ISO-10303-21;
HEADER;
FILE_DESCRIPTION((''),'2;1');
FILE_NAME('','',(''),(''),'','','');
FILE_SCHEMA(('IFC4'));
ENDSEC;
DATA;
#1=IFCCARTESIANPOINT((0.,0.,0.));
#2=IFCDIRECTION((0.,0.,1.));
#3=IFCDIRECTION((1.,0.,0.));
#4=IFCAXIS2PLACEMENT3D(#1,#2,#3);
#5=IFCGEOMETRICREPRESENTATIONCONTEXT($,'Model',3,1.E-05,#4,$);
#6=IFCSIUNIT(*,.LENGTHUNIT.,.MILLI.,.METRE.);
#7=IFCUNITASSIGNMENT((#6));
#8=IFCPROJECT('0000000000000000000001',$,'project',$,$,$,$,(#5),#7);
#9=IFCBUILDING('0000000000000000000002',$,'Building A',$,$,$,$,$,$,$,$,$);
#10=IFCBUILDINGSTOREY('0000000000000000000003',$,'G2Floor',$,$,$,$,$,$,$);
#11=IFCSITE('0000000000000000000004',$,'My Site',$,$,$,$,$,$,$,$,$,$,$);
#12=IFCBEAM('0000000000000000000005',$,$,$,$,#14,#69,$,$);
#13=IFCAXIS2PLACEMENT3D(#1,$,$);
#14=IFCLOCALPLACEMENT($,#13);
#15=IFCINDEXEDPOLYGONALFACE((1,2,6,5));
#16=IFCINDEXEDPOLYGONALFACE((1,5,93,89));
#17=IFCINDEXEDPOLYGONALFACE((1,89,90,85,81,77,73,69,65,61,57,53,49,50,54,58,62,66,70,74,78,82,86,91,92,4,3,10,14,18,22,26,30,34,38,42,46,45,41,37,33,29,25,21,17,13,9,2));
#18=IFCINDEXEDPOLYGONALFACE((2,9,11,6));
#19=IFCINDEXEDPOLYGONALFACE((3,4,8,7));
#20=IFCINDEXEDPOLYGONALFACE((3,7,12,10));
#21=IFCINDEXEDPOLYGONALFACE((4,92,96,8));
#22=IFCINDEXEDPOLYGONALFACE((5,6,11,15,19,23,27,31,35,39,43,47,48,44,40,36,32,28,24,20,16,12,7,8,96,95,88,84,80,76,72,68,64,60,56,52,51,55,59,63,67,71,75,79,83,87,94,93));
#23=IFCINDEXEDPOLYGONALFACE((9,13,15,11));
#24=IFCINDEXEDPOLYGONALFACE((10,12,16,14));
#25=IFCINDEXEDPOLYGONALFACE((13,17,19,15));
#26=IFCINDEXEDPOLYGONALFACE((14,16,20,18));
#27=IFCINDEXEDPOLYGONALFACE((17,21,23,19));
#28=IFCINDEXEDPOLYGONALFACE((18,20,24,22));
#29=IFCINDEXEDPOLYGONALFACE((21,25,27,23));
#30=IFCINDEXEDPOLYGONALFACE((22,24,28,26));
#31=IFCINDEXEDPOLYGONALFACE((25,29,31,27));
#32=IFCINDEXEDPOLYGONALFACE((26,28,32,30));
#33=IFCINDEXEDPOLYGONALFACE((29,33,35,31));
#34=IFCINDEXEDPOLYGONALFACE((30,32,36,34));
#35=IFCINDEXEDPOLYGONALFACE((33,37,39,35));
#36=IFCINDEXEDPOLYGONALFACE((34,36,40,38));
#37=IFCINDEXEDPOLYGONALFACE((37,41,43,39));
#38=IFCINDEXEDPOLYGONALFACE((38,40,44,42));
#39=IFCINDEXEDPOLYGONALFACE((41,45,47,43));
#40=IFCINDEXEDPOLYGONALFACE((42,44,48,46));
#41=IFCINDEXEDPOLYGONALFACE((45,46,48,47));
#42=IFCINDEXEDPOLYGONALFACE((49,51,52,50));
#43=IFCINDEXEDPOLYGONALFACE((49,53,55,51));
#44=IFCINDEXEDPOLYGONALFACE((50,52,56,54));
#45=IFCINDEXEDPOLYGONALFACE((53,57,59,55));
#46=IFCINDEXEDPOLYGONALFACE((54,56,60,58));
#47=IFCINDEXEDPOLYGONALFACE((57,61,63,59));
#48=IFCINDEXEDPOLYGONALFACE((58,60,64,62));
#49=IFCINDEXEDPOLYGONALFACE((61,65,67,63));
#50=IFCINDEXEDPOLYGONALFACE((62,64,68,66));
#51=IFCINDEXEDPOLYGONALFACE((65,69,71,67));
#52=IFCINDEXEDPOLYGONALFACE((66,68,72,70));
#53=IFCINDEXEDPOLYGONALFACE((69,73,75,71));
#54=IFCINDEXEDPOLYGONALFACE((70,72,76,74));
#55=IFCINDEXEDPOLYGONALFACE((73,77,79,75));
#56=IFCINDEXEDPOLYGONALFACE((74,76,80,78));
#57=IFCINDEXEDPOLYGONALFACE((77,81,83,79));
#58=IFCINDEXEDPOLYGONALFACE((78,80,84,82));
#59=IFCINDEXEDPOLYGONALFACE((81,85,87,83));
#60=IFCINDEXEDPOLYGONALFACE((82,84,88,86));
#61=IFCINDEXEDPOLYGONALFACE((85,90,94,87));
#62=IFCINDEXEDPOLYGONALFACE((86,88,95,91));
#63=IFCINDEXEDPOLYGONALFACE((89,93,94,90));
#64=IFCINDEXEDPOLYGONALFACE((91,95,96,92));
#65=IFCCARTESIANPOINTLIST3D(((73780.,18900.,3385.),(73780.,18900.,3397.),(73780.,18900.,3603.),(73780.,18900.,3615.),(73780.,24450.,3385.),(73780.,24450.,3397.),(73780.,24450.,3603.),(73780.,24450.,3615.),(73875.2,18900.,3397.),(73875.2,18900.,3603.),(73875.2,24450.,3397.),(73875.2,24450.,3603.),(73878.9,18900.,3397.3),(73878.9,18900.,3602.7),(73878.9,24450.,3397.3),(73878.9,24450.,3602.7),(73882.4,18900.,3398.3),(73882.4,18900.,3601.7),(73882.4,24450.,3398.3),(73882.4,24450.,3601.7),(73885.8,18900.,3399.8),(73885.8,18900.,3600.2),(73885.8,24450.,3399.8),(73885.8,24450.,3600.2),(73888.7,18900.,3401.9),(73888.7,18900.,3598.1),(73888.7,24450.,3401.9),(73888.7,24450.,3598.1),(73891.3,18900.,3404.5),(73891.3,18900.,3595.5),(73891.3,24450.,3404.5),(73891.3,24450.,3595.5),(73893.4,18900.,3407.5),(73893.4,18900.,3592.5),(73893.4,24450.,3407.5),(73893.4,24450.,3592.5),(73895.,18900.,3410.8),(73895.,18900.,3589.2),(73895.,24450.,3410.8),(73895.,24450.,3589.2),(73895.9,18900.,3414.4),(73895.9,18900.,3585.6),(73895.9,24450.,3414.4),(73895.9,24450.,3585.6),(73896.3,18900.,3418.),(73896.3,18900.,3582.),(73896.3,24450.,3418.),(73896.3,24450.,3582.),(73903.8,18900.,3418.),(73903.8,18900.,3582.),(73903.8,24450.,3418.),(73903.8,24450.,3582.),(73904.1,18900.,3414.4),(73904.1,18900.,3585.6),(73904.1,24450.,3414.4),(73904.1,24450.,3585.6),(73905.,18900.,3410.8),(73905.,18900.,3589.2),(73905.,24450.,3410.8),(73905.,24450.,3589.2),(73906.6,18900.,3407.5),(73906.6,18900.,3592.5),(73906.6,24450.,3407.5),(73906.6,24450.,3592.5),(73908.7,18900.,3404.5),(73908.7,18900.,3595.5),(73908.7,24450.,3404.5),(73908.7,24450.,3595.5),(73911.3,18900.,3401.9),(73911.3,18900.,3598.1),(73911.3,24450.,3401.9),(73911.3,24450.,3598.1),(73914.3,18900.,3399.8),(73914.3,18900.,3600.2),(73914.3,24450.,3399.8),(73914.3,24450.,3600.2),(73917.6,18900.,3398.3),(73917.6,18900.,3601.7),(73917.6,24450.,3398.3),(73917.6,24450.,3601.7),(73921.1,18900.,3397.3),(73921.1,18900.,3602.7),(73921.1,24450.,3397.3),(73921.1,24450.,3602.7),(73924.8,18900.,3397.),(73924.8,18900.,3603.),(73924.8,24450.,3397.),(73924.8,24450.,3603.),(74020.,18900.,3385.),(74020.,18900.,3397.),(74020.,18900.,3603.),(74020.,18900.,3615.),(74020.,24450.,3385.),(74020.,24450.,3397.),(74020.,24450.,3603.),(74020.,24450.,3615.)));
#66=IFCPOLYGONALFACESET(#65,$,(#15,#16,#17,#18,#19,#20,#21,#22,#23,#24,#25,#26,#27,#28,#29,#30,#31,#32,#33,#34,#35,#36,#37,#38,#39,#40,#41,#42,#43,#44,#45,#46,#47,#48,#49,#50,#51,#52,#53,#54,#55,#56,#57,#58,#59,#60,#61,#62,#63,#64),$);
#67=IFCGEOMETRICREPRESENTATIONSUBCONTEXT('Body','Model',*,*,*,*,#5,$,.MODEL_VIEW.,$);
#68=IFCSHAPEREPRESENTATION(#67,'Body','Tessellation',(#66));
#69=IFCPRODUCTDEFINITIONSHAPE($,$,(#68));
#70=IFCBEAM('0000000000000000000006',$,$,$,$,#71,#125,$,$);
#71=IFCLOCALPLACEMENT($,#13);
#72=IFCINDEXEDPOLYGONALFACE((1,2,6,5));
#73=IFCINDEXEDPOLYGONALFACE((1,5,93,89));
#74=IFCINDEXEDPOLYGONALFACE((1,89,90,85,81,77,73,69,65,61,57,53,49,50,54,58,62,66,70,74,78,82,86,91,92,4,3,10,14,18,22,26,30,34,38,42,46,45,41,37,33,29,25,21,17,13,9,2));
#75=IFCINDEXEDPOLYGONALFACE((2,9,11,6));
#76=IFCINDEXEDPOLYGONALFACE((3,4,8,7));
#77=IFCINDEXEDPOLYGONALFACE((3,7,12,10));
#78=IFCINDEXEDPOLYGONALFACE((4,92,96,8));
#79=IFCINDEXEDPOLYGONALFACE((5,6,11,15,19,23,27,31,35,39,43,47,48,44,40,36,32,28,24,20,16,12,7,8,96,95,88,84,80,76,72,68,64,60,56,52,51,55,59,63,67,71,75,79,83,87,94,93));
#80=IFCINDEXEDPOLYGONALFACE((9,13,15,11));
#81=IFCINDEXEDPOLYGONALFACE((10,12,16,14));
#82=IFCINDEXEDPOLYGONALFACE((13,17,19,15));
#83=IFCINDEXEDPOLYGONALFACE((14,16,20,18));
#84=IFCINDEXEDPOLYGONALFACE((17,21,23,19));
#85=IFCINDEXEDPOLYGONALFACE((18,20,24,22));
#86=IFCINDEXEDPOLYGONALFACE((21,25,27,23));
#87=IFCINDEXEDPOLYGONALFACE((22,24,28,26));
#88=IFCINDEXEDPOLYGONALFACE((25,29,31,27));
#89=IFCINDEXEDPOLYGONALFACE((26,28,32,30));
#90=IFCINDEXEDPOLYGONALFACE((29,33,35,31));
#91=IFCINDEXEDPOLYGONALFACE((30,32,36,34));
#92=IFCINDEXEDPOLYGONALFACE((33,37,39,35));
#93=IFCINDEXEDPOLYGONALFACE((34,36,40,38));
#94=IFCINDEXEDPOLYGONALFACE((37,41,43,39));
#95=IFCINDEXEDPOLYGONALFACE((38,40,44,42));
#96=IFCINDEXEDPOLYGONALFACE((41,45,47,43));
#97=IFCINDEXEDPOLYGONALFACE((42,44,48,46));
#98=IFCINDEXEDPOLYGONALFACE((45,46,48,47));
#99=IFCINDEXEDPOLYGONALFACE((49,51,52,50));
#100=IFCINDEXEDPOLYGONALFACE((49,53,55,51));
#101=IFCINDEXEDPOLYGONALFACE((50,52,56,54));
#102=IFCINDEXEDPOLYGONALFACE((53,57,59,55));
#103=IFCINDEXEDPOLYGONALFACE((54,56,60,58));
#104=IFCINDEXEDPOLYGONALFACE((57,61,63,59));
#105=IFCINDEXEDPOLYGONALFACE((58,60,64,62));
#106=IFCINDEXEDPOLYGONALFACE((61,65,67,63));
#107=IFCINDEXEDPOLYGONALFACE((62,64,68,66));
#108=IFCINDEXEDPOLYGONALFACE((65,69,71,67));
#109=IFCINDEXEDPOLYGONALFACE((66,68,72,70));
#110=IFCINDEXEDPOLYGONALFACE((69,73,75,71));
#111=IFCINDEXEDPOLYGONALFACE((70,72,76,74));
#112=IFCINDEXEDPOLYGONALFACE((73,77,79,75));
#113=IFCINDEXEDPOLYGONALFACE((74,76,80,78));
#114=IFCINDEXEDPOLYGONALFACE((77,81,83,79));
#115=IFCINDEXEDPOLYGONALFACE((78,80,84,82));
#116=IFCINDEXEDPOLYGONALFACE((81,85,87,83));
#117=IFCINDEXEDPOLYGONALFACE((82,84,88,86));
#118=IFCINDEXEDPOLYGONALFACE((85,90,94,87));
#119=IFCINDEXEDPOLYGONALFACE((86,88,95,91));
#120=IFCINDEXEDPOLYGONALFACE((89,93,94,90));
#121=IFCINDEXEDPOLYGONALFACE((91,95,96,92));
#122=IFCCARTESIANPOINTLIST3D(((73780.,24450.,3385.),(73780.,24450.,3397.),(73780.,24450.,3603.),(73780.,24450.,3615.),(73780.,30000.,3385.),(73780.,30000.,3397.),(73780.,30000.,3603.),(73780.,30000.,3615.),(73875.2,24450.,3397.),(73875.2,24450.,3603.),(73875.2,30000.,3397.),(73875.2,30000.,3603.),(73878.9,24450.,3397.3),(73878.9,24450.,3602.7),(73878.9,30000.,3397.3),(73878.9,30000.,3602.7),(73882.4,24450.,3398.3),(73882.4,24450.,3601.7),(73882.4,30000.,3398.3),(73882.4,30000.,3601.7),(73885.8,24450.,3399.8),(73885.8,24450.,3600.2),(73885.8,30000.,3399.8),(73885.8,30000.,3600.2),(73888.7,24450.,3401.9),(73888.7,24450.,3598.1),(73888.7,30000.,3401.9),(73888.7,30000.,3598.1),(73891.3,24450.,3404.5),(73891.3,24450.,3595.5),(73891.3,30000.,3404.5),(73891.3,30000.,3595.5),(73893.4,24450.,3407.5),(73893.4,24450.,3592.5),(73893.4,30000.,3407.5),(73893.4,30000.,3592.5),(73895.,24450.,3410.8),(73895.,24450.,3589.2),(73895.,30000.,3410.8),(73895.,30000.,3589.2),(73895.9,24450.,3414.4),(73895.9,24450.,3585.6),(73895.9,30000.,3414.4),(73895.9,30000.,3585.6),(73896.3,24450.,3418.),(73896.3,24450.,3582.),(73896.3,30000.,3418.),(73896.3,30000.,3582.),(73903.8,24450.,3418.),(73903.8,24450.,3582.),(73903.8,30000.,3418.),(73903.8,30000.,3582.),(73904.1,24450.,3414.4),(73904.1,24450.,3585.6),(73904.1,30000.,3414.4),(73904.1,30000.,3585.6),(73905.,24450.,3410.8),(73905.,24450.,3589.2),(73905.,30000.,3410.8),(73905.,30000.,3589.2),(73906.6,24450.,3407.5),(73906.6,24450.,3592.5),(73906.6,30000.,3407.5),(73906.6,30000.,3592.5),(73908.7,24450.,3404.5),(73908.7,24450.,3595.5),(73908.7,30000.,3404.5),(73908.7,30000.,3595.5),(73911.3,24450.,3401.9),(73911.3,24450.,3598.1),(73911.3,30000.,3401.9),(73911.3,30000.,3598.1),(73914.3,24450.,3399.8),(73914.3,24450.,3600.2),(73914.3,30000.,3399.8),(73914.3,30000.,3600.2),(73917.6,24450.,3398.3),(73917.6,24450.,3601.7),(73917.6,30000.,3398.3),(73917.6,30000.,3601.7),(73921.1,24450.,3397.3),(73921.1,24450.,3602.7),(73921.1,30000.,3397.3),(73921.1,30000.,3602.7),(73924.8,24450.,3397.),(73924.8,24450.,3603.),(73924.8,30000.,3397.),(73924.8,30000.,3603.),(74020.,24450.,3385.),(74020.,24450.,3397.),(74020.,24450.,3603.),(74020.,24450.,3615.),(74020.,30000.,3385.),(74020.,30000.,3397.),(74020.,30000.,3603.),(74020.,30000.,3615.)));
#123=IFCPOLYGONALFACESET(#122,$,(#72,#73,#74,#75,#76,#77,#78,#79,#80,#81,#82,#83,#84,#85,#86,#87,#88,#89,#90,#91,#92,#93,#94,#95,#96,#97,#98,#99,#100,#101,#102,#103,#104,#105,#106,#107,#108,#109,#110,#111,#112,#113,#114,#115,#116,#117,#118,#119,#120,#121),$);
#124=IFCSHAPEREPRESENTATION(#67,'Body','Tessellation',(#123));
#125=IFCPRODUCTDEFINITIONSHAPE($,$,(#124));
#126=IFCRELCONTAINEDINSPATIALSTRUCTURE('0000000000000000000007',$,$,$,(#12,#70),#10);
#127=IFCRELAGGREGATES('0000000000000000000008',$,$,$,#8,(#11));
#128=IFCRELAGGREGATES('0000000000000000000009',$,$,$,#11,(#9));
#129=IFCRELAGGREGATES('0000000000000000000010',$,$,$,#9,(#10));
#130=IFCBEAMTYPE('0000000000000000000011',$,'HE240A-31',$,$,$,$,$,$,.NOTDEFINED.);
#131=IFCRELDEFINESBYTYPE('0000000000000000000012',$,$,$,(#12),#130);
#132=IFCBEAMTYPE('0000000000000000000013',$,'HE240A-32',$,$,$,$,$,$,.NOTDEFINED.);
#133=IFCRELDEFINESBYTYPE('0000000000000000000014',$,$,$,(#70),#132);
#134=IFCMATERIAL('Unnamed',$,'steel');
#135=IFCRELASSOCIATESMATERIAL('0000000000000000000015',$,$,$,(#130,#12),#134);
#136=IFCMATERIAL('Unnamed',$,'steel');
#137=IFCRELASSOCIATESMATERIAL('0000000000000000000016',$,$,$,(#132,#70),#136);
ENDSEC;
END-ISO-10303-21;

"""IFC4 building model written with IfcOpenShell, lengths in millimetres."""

from ifc_helpers import new_model, si_unit, frame, origin_with_axes, place, context, subcontext, project, spatial, polyline, outline, extrude, material, material_profile, profile_set, profile_usage, type_object, element, save


model = new_model("IFC4")

# Units and contexts
model_context = context("Model", 3, precision=1e-05, world=origin_with_axes())
body_context = subcontext(model_context, "Body", "Model", "MODEL_VIEW")
ifc_project = project(units=[si_unit("LENGTHUNIT", "METRE", prefix="MILLI")], contexts=[model_context])

# Site, building, storey
site = spatial("IfcSite", under=ifc_project, Name="My Site")
building = spatial("IfcBuilding", under=site, Name="Building A")
storey = spatial("IfcBuildingStorey", under=building, Name="G2Floor")

# Beams
ifc_material_1 = material(Name="Unnamed", Category="steel")
ifc_material_profile_1 = material_profile(ifc_material_1, outline(polyline([(120.0, -115.0), (120.0, -103.0), (120.0, -103.0), (24.8, -103.0), (24.8, -103.0), (21.1, -102.7), (21.1, -102.7), (17.6, -101.7), (17.6, -101.7), (14.2, -100.2), (14.2, -100.2), (11.3, -98.1), (11.3, -98.1), (8.7, -95.5), (8.7, -95.5), (6.6, -92.5), (6.6, -92.5), (5.0, -89.2), (5.0, -89.2), (4.1, -85.6), (4.1, -85.6), (3.8, -82.0), (3.8, -82.0), (3.8, 82.0), (3.8, 82.0), (4.1, 85.6), (4.1, 85.6), (5.0, 89.2), (5.0, 89.2), (6.6, 92.5), (6.6, 92.5), (8.7, 95.5), (8.7, 95.5), (11.3, 98.1), (11.3, 98.1), (14.2, 100.2), (14.2, 100.2), (17.6, 101.7), (17.6, 101.7), (21.1, 102.7), (21.1, 102.7), (24.8, 103.0), (24.8, 103.0), (120.0, 103.0), (120.0, 103.0), (120.0, 115.0), (120.0, 115.0), (-120.0, 115.0), (-120.0, 115.0), (-120.0, 103.0), (-120.0, 103.0), (-24.8, 103.0), (-24.8, 103.0), (-21.1, 102.7), (-21.1, 102.7), (-17.6, 101.7), (-17.6, 101.7), (-14.2, 100.2), (-14.2, 100.2), (-11.3, 98.1), (-11.3, 98.1), (-8.7, 95.5), (-8.7, 95.5), (-6.6, 92.5), (-6.6, 92.5), (-5.0, 89.2), (-5.0, 89.2), (-4.1, 85.6), (-4.1, 85.6), (-3.8, 82.0), (-3.8, 82.0), (-3.8, -82.0), (-3.8, -82.0), (-4.1, -85.6), (-4.1, -85.6), (-5.0, -89.2), (-5.0, -89.2), (-6.6, -92.5), (-6.6, -92.5), (-8.7, -95.5), (-8.7, -95.5), (-11.3, -98.1), (-11.3, -98.1), (-14.2, -100.2), (-14.2, -100.2), (-17.6, -101.7), (-17.6, -101.7), (-21.1, -102.7), (-21.1, -102.7), (-24.8, -103.0), (-24.8, -103.0), (-120.0, -103.0), (-120.0, -103.0), (-120.0, -115.0), (-120.0, -115.0), (120.0, -115.0)])))
ifc_profile_set_1 = profile_set([ifc_material_profile_1], Name="HE240A-31")
ifc_profile_usage_1 = profile_usage(ifc_profile_set_1)
beam_type_1 = type_object("IfcBeamType", Name="HE240A-31", PredefinedType="NOTDEFINED", material=ifc_profile_set_1)
beam_1_placement = place(None, frame((73900.0, 18900.0, 3500.0), z_axis=(0.0, 1.0, 0.0), x_axis=(1.0, 0.0, 0.0)))
element("IfcBeam", 1, at=beam_1_placement, inside=storey, type_object=beam_type_1, material=ifc_profile_usage_1, context=body_context, shape_type="SweptSolid", body=[
    extrude(outline(polyline([(120.0, -115.0), (120.0, -103.0), (120.0, -103.0), (24.8, -103.0), (24.8, -103.0), (21.1, -102.7), (21.1, -102.7), (17.6, -101.7), (17.6, -101.7), (14.2, -100.2), (14.2, -100.2), (11.3, -98.1), (11.3, -98.1), (8.7, -95.5), (8.7, -95.5), (6.6, -92.5), (6.6, -92.5), (5.0, -89.2), (5.0, -89.2), (4.1, -85.6), (4.1, -85.6), (3.8, -82.0), (3.8, -82.0), (3.8, 82.0), (3.8, 82.0), (4.1, 85.6), (4.1, 85.6), (5.0, 89.2), (5.0, 89.2), (6.6, 92.5), (6.6, 92.5), (8.7, 95.5), (8.7, 95.5), (11.3, 98.1), (11.3, 98.1), (14.2, 100.2), (14.2, 100.2), (17.6, 101.7), (17.6, 101.7), (21.1, 102.7), (21.1, 102.7), (24.8, 103.0), (24.8, 103.0), (120.0, 103.0), (120.0, 103.0), (120.0, 115.0), (120.0, 115.0), (-120.0, 115.0), (-120.0, 115.0), (-120.0, 103.0), (-120.0, 103.0), (-24.8, 103.0), (-24.8, 103.0), (-21.1, 102.7), (-21.1, 102.7), (-17.6, 101.7), (-17.6, 101.7), (-14.2, 100.2), (-14.2, 100.2), (-11.3, 98.1), (-11.3, 98.1), (-8.7, 95.5), (-8.7, 95.5), (-6.6, 92.5), (-6.6, 92.5), (-5.0, 89.2), (-5.0, 89.2), (-4.1, 85.6), (-4.1, 85.6), (-3.8, 82.0), (-3.8, 82.0), (-3.8, -82.0), (-3.8, -82.0), (-4.1, -85.6), (-4.1, -85.6), (-5.0, -89.2), (-5.0, -89.2), (-6.6, -92.5), (-6.6, -92.5), (-8.7, -95.5), (-8.7, -95.5), (-11.3, -98.1), (-11.3, -98.1), (-14.2, -100.2), (-14.2, -100.2), (-17.6, -101.7), (-17.6, -101.7), (-21.1, -102.7), (-21.1, -102.7), (-24.8, -103.0), (-24.8, -103.0), (-120.0, -103.0), (-120.0, -103.0), (-120.0, -115.0), (-120.0, -115.0), (120.0, -115.0)])), origin_with_axes(), (0.0, 0.0, 1.0), 5550.0),
])
ifc_material_2 = material(Name="Unnamed", Category="steel")
ifc_material_profile_2 = material_profile(ifc_material_2, outline(polyline([(120.0, -115.0), (120.0, -103.0), (120.0, -103.0), (24.8, -103.0), (24.8, -103.0), (21.1, -102.7), (21.1, -102.7), (17.6, -101.7), (17.6, -101.7), (14.2, -100.2), (14.2, -100.2), (11.3, -98.1), (11.3, -98.1), (8.7, -95.5), (8.7, -95.5), (6.6, -92.5), (6.6, -92.5), (5.0, -89.2), (5.0, -89.2), (4.1, -85.6), (4.1, -85.6), (3.8, -82.0), (3.8, -82.0), (3.8, 82.0), (3.8, 82.0), (4.1, 85.6), (4.1, 85.6), (5.0, 89.2), (5.0, 89.2), (6.6, 92.5), (6.6, 92.5), (8.7, 95.5), (8.7, 95.5), (11.3, 98.1), (11.3, 98.1), (14.2, 100.2), (14.2, 100.2), (17.6, 101.7), (17.6, 101.7), (21.1, 102.7), (21.1, 102.7), (24.8, 103.0), (24.8, 103.0), (120.0, 103.0), (120.0, 103.0), (120.0, 115.0), (120.0, 115.0), (-120.0, 115.0), (-120.0, 115.0), (-120.0, 103.0), (-120.0, 103.0), (-24.8, 103.0), (-24.8, 103.0), (-21.1, 102.7), (-21.1, 102.7), (-17.6, 101.7), (-17.6, 101.7), (-14.2, 100.2), (-14.2, 100.2), (-11.3, 98.1), (-11.3, 98.1), (-8.7, 95.5), (-8.7, 95.5), (-6.6, 92.5), (-6.6, 92.5), (-5.0, 89.2), (-5.0, 89.2), (-4.1, 85.6), (-4.1, 85.6), (-3.8, 82.0), (-3.8, 82.0), (-3.8, -82.0), (-3.8, -82.0), (-4.1, -85.6), (-4.1, -85.6), (-5.0, -89.2), (-5.0, -89.2), (-6.6, -92.5), (-6.6, -92.5), (-8.7, -95.5), (-8.7, -95.5), (-11.3, -98.1), (-11.3, -98.1), (-14.2, -100.2), (-14.2, -100.2), (-17.6, -101.7), (-17.6, -101.7), (-21.1, -102.7), (-21.1, -102.7), (-24.8, -103.0), (-24.8, -103.0), (-120.0, -103.0), (-120.0, -103.0), (-120.0, -115.0), (-120.0, -115.0), (120.0, -115.0)])))
ifc_profile_set_2 = profile_set([ifc_material_profile_2], Name="HE240A-32")
ifc_profile_usage_2 = profile_usage(ifc_profile_set_2)
beam_type_2 = type_object("IfcBeamType", Name="HE240A-32", PredefinedType="NOTDEFINED", material=ifc_profile_set_2)
beam_2_placement = place(None, frame((73900.0, 24450.0, 3500.0), z_axis=(0.0, 1.0, 0.0), x_axis=(1.0, 0.0, 0.0)))
element("IfcBeam", 2, at=beam_2_placement, inside=storey, type_object=beam_type_2, material=ifc_profile_usage_2, context=body_context, shape_type="SweptSolid", body=[
    extrude(outline(polyline([(120.0, -115.0), (120.0, -103.0), (120.0, -103.0), (24.8, -103.0), (24.8, -103.0), (21.1, -102.7), (21.1, -102.7), (17.6, -101.7), (17.6, -101.7), (14.2, -100.2), (14.2, -100.2), (11.3, -98.1), (11.3, -98.1), (8.7, -95.5), (8.7, -95.5), (6.6, -92.5), (6.6, -92.5), (5.0, -89.2), (5.0, -89.2), (4.1, -85.6), (4.1, -85.6), (3.8, -82.0), (3.8, -82.0), (3.8, 82.0), (3.8, 82.0), (4.1, 85.6), (4.1, 85.6), (5.0, 89.2), (5.0, 89.2), (6.6, 92.5), (6.6, 92.5), (8.7, 95.5), (8.7, 95.5), (11.3, 98.1), (11.3, 98.1), (14.2, 100.2), (14.2, 100.2), (17.6, 101.7), (17.6, 101.7), (21.1, 102.7), (21.1, 102.7), (24.8, 103.0), (24.8, 103.0), (120.0, 103.0), (120.0, 103.0), (120.0, 115.0), (120.0, 115.0), (-120.0, 115.0), (-120.0, 115.0), (-120.0, 103.0), (-120.0, 103.0), (-24.8, 103.0), (-24.8, 103.0), (-21.1, 102.7), (-21.1, 102.7), (-17.6, 101.7), (-17.6, 101.7), (-14.2, 100.2), (-14.2, 100.2), (-11.3, 98.1), (-11.3, 98.1), (-8.7, 95.5), (-8.7, 95.5), (-6.6, 92.5), (-6.6, 92.5), (-5.0, 89.2), (-5.0, 89.2), (-4.1, 85.6), (-4.1, 85.6), (-3.8, 82.0), (-3.8, 82.0), (-3.8, -82.0), (-3.8, -82.0), (-4.1, -85.6), (-4.1, -85.6), (-5.0, -89.2), (-5.0, -89.2), (-6.6, -92.5), (-6.6, -92.5), (-8.7, -95.5), (-8.7, -95.5), (-11.3, -98.1), (-11.3, -98.1), (-14.2, -100.2), (-14.2, -100.2), (-17.6, -101.7), (-17.6, -101.7), (-21.1, -102.7), (-21.1, -102.7), (-24.8, -103.0), (-24.8, -103.0), (-120.0, -103.0), (-120.0, -103.0), (-120.0, -115.0), (-120.0, -115.0), (120.0, -115.0)])), origin_with_axes(), (0.0, 0.0, 1.0), 5550.0),
])

save(model, "model.ifc")
